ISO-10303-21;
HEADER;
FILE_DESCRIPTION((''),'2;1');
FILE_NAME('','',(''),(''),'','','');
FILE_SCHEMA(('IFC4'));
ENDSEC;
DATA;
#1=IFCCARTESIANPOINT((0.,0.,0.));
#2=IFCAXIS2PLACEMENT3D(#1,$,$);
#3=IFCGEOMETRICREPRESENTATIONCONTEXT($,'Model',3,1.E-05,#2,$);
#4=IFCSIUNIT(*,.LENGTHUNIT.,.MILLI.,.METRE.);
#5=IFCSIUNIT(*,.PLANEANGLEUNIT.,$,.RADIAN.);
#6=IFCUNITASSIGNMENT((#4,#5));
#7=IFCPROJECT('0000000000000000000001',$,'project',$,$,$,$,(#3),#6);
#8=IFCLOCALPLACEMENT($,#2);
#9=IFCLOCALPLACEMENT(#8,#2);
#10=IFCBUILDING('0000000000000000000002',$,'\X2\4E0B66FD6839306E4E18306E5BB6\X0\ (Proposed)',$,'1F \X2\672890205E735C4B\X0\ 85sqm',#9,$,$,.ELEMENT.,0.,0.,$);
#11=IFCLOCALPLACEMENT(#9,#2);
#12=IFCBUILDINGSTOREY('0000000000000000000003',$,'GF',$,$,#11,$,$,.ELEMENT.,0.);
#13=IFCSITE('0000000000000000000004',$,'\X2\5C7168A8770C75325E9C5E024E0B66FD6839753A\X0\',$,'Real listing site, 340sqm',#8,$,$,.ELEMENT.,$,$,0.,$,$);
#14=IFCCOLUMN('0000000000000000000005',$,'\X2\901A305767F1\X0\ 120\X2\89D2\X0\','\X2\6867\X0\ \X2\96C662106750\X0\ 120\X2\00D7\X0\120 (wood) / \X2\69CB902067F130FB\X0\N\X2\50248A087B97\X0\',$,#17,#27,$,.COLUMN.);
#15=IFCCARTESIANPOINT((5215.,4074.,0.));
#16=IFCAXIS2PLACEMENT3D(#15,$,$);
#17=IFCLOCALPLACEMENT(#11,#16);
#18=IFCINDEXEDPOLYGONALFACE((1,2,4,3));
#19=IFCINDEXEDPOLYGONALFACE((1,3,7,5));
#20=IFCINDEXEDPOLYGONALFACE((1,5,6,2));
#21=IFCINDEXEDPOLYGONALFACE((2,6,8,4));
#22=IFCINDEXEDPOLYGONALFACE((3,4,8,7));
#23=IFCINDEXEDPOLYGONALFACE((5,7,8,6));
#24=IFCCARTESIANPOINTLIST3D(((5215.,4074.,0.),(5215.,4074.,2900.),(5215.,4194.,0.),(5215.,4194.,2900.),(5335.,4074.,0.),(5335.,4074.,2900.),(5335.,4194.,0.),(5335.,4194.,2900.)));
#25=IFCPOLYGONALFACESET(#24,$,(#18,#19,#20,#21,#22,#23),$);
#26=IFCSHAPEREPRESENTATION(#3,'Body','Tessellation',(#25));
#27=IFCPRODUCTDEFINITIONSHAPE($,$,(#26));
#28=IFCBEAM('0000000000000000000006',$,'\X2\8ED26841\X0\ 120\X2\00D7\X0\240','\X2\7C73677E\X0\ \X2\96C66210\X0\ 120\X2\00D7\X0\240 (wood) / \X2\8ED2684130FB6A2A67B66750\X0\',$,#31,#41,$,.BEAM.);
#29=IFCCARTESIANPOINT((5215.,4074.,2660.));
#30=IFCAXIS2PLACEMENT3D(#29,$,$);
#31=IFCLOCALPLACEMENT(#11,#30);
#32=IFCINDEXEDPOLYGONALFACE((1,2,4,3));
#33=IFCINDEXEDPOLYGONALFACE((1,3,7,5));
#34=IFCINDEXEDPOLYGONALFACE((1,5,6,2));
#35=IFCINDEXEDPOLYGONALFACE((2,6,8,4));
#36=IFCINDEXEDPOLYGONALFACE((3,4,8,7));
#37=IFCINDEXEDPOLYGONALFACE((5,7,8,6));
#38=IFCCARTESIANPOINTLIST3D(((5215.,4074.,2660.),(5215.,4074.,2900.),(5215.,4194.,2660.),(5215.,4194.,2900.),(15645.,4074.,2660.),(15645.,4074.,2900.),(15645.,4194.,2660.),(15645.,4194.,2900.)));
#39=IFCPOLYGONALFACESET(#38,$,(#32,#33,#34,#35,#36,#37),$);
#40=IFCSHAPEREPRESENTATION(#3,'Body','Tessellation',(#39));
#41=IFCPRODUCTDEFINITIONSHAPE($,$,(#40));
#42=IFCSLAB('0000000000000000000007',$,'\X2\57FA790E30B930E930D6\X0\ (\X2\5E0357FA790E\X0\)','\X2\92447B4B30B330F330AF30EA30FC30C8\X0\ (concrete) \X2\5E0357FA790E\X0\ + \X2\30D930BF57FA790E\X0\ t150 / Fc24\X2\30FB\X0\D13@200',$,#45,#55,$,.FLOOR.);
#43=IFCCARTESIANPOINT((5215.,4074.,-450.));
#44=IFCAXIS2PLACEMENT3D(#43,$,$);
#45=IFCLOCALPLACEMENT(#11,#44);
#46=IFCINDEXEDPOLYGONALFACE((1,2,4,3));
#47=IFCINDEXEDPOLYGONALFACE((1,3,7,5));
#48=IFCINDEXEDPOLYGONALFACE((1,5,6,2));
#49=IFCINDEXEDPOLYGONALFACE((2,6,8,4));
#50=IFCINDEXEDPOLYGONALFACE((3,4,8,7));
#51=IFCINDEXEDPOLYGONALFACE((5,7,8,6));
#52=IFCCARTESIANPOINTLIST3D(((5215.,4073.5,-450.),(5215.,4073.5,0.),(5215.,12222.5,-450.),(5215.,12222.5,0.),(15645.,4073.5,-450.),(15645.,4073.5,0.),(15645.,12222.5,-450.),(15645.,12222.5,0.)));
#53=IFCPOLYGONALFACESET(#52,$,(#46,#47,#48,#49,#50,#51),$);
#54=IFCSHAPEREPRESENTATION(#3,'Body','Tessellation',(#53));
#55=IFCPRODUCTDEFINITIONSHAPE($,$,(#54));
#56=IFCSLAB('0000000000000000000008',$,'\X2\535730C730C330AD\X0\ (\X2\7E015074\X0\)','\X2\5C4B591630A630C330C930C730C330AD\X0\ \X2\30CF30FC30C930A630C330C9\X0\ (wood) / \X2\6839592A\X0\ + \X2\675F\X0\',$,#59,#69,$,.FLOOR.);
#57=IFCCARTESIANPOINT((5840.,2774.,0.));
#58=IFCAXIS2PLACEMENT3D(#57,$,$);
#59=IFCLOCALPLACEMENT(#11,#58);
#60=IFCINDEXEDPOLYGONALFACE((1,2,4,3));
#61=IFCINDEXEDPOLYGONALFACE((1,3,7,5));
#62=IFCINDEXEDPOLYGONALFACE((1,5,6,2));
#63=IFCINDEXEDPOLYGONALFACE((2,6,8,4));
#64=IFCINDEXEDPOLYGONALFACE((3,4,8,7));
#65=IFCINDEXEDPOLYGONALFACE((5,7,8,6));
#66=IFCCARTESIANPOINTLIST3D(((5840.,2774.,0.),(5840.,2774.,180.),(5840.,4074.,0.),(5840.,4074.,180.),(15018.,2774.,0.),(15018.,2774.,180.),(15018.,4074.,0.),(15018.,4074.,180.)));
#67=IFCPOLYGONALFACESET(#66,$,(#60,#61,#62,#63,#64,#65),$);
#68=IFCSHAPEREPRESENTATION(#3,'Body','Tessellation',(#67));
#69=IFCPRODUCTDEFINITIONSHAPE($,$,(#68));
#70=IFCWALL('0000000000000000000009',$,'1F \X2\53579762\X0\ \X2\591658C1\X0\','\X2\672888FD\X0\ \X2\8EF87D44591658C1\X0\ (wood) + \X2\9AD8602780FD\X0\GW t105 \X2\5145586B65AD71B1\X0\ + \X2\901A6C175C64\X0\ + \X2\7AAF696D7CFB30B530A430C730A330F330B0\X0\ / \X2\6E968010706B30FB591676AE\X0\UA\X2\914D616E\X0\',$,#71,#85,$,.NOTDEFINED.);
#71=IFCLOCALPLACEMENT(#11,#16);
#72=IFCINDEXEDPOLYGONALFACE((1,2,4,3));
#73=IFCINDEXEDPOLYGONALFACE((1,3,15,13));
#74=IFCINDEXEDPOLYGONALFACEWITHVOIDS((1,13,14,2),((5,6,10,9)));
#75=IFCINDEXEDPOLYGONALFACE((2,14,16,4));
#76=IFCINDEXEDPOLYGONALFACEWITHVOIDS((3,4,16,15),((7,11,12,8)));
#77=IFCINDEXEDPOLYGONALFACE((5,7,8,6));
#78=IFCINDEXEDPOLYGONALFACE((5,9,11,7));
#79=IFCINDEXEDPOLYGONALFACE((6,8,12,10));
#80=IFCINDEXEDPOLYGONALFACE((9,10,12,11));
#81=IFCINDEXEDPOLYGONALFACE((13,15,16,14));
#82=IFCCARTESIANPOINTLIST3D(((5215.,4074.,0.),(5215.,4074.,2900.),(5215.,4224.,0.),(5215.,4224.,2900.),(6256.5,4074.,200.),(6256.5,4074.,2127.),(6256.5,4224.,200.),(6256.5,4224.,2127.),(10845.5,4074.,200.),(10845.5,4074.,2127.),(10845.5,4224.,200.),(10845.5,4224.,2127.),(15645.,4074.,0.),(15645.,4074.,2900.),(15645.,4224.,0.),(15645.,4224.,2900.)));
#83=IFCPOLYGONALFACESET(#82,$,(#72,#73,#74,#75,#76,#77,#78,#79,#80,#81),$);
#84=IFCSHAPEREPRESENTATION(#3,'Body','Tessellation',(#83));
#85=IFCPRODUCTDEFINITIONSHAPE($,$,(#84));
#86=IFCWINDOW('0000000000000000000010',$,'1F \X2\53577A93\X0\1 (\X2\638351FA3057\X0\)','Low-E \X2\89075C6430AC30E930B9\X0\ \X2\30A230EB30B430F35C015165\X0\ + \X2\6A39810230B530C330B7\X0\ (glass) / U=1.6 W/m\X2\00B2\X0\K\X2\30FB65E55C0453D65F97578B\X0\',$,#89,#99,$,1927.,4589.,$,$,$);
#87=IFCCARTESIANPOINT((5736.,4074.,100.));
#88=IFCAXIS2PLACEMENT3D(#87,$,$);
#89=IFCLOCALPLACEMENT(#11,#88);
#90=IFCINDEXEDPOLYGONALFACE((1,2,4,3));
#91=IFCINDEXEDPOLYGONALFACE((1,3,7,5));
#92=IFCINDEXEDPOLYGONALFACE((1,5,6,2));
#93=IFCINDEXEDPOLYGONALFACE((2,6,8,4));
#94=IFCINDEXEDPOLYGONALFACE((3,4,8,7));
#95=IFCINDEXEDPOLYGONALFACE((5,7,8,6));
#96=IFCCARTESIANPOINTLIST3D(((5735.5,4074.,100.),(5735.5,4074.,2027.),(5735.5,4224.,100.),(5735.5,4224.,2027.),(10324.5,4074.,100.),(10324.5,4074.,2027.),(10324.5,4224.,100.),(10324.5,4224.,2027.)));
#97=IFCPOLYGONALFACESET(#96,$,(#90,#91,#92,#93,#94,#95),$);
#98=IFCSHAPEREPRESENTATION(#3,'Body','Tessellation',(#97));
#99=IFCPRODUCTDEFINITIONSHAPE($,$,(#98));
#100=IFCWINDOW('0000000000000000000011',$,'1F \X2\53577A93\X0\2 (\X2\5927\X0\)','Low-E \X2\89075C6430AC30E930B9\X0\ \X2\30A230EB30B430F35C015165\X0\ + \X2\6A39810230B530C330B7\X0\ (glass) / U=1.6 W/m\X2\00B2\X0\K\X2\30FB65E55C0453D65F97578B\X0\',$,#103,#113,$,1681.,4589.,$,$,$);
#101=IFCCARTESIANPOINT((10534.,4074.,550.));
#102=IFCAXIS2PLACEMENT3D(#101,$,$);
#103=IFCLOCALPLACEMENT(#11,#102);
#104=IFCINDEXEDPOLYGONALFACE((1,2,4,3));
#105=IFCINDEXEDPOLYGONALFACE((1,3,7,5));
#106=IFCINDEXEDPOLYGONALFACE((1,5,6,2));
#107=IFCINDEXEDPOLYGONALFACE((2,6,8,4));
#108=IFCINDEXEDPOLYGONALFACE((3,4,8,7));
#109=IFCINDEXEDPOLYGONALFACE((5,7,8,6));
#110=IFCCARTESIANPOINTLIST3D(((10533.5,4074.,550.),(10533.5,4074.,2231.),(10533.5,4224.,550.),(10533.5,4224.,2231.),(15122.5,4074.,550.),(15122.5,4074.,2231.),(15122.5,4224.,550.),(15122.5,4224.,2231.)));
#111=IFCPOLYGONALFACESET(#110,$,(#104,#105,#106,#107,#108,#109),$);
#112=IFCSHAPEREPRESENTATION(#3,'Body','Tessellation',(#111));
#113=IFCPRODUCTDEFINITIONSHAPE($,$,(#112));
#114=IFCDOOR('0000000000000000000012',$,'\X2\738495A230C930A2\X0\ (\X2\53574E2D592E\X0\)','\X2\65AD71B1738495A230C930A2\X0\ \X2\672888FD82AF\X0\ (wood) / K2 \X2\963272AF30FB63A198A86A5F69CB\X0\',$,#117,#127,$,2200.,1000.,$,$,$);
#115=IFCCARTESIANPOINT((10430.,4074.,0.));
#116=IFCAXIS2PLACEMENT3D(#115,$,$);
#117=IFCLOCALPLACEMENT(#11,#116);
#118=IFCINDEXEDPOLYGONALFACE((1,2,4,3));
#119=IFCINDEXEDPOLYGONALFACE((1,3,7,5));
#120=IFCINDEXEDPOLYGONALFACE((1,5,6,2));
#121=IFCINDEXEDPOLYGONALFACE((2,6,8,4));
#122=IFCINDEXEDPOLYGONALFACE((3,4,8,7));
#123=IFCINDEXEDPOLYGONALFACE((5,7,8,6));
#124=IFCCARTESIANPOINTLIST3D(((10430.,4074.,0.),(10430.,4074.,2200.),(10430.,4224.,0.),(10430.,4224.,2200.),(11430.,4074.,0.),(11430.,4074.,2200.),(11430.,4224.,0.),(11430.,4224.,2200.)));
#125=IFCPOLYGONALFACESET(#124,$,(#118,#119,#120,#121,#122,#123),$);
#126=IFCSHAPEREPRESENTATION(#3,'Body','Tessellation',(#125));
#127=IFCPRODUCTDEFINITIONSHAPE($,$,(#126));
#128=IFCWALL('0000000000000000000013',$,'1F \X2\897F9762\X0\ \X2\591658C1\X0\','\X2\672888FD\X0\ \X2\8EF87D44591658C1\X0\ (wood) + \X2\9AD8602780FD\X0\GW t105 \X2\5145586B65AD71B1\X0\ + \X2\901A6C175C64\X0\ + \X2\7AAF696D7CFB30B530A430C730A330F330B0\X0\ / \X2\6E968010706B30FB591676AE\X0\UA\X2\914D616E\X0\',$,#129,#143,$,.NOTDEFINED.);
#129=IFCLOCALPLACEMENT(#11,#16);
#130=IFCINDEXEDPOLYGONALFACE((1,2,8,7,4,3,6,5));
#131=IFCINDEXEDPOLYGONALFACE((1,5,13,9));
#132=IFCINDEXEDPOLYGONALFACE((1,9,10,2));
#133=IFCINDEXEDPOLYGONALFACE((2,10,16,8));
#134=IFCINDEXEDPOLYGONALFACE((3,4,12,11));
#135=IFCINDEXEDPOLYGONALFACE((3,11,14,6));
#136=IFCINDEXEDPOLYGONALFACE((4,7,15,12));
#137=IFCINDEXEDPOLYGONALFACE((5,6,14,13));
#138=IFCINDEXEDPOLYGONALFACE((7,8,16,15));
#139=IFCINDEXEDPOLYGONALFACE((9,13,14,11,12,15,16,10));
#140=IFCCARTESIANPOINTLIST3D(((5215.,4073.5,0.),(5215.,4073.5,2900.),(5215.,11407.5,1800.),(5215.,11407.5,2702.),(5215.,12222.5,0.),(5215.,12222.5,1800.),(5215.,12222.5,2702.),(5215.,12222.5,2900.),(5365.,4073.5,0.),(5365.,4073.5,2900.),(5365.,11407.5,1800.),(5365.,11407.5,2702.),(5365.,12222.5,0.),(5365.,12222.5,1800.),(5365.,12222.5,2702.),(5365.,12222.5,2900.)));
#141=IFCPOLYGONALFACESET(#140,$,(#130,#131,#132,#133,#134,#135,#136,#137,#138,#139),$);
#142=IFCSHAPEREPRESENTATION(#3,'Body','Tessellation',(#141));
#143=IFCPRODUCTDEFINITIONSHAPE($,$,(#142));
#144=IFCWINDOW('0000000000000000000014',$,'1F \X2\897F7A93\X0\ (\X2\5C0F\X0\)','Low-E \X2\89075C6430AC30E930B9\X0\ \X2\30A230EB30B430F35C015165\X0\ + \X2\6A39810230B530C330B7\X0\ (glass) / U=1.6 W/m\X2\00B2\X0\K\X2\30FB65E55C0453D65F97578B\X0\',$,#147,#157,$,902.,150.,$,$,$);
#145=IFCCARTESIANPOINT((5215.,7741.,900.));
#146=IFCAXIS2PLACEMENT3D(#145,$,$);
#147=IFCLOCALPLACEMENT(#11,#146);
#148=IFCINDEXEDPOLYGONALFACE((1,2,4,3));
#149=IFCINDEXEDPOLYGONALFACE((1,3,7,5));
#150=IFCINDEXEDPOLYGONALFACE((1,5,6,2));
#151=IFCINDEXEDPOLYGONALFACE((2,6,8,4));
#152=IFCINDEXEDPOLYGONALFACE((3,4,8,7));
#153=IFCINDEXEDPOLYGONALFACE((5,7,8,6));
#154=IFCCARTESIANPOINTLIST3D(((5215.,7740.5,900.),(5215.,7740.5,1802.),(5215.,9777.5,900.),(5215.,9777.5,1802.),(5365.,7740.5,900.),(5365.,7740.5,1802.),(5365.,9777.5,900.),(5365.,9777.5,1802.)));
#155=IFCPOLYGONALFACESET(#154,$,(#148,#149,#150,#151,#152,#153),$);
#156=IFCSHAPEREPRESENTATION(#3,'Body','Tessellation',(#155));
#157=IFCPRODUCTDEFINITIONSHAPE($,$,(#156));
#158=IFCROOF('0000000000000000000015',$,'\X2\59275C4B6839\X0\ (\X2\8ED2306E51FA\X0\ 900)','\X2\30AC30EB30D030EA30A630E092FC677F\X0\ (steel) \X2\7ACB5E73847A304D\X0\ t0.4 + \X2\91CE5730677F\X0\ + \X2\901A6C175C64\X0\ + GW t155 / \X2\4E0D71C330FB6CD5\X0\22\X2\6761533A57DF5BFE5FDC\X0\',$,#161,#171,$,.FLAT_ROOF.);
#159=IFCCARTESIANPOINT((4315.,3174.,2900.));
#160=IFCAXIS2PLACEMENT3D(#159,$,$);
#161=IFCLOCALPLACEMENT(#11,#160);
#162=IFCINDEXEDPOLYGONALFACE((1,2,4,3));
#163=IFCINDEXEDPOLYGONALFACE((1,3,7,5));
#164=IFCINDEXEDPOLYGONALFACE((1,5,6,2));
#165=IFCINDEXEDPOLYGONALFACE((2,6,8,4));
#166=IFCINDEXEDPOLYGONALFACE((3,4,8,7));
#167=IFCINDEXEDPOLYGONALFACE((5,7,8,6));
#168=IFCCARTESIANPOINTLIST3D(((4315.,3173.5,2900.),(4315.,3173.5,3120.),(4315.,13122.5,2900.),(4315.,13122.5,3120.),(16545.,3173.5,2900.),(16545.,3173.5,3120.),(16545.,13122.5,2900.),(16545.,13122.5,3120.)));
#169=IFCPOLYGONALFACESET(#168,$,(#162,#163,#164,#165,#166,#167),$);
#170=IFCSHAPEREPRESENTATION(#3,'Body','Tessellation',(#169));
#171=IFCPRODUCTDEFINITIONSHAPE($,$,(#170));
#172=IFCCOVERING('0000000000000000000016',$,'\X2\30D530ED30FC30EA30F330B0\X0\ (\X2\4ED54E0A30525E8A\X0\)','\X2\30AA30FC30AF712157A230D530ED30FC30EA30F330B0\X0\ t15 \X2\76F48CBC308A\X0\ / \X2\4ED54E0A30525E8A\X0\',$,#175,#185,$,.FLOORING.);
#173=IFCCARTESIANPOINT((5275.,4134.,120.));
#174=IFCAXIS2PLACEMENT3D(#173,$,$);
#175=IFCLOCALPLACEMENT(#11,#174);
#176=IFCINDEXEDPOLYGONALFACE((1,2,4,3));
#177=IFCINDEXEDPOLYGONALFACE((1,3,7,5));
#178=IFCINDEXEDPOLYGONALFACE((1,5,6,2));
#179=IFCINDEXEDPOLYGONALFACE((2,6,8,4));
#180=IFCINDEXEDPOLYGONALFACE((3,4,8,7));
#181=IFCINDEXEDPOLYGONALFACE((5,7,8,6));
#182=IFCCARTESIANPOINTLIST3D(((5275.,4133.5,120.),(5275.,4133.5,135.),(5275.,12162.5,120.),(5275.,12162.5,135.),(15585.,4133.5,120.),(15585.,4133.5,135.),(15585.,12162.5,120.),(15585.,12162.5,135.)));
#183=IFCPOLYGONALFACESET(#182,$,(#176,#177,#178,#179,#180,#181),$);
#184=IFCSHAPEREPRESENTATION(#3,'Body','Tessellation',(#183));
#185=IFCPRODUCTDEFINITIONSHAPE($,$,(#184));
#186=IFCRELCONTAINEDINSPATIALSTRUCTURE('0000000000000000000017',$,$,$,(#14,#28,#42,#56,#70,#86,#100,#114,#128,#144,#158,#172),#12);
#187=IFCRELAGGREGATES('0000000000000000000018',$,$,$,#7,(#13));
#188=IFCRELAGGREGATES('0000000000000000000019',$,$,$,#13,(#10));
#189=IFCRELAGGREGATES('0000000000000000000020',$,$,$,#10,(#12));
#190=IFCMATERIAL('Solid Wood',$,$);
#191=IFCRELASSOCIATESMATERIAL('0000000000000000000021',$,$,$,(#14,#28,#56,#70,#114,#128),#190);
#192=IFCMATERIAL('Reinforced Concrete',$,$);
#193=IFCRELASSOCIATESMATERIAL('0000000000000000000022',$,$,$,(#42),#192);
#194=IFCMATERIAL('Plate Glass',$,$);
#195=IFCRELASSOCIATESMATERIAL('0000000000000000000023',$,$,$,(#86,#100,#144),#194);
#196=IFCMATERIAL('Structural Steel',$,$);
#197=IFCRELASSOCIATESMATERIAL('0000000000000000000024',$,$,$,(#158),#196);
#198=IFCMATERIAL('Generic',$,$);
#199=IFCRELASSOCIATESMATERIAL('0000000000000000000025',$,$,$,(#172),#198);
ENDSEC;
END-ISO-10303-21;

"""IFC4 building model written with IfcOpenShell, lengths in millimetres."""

from ifc_helpers import new_model, si_unit, frame, frame_2d, origin, place, context, project, spatial, rectangle, extrude, material, element, fill, save


model = new_model("IFC4")

# Units and contexts
model_context = context("Model", 3, precision=1e-05, world=origin())
ifc_project = project(units=[si_unit("LENGTHUNIT", "METRE", prefix="MILLI"), si_unit("PLANEANGLEUNIT", "RADIAN")], contexts=[model_context])

# Site, building, storey
site_placement = place(None, origin())
site = spatial("IfcSite", under=ifc_project, at=site_placement, Name="山梨県甲府市下曽根町", ObjectType="Real listing site, 340sqm", CompositionType="ELEMENT", RefElevation=0.0)
building_placement = place(site_placement, origin())
building = spatial("IfcBuilding", under=site, at=building_placement, Name="下曽根の丘の家 (Proposed)", ObjectType="1F 木造平屋 85sqm", CompositionType="ELEMENT", ElevationOfRefHeight=0.0, ElevationOfTerrain=0.0)
storey_placement = place(building_placement, origin())
storey = spatial("IfcBuildingStorey", under=building, at=storey_placement, Name="GF", CompositionType="ELEMENT", Elevation=0.0)

# Column
ifc_material_1 = material(Name="Solid Wood")
column_1_placement = place(storey_placement, frame((5215.0, 4074.0, 0.0)))
element("IfcColumn", 1, at=column_1_placement, inside=storey, material=ifc_material_1, Name="通し柱 120角", Description="桧 集成材 120×120 (wood) / 構造柱・N値計算", PredefinedType="COLUMN", context=model_context, shape_type="SweptSolid", body=[
    extrude(rectangle(XDim=120.0, YDim=120.0, at=frame_2d((60.0, 60.0))), frame((5215.0, 4074.0, 0.0)), (0.0, 0.0, 1.0), 2900.0),
])

# Beam
beam_1_placement = place(storey_placement, frame((5215.0, 4074.0, 2660.0)))
element("IfcBeam", 2, at=beam_1_placement, inside=storey, material=ifc_material_1, Name="軒桁 120×240", Description="米松 集成 120×240 (wood) / 軒桁・横架材", PredefinedType="BEAM", context=model_context, shape_type="SweptSolid", body=[
    extrude(rectangle(XDim=10430.0, YDim=120.0, at=frame_2d((5215.0, 60.0))), frame((5215.0, 4074.0, 2660.0)), (0.0, 0.0, 1.0), 240.0),
])

# Slabs
ifc_material_2 = material(Name="Reinforced Concrete")
slab_1_placement = place(storey_placement, frame((5215.0, 4074.0, -450.0)))
element("IfcSlab", 3, at=slab_1_placement, inside=storey, material=ifc_material_2, Name="基礎スラブ (布基礎)", Description="鉄筋コンクリート (concrete) 布基礎 + ベタ基礎 t150 / Fc24・D13@200", PredefinedType="FLOOR", context=model_context, shape_type="SweptSolid", body=[
    extrude(rectangle(XDim=10430.0, YDim=8149.0, at=frame_2d((5215.0, 4074.0))), frame((5215.0, 4074.0, -450.0)), (0.0, 0.0, 1.0), 450.0),
])
slab_2_placement = place(storey_placement, frame((5840.0, 2774.0, 0.0)))
element("IfcSlab", 4, at=slab_2_placement, inside=storey, material=ifc_material_1, Name="南デッキ (縁側)", Description="屋外ウッドデッキ ハードウッド (wood) / 根太 + 束", PredefinedType="FLOOR", context=model_context, shape_type="SweptSolid", body=[
    extrude(rectangle(XDim=9178.0, YDim=1300.0, at=frame_2d((4589.0, 650.0))), frame((5840.0, 2774.0, 0.0)), (0.0, 0.0, 1.0), 180.0),
])

# Wall, openings, windows, door
wall_1_placement = place(storey_placement, frame((5215.0, 4074.0, 0.0)))
wall_1 = element("IfcWall", 5, at=wall_1_placement, inside=storey, material=ifc_material_1, Name="1F 南面 外壁", Description="木製 軸組外壁 (wood) + 高性能GW t105 充填断熱 + 通気層 + 窯業系サイディング / 準耐火・外皮UA配慮", PredefinedType="NOTDEFINED", context=model_context, shape_type="SweptSolid", body=[
    extrude(rectangle(XDim=10430.0, YDim=150.0, at=frame_2d((5215.0, 75.0))), frame((5215.0, 4074.0, 0.0)), (0.0, 0.0, 1.0), 2900.0),
])
opening_1_placement = place(storey_placement, frame((5736.0, 4074.0, 100.0)))
opening_1 = element("IfcOpeningElement", 6, at=opening_1_placement, cuts=wall_1, PredefinedType="NOTDEFINED", context=model_context, shape_type="SweptSolid", body=[
    extrude(rectangle(XDim=4589.0, YDim=150.0, at=frame_2d((2294.0, 75.0))), frame((5736.0, 4074.0, 100.0)), (0.0, 0.0, 1.0), 1927.0),
])
opening_2_placement = place(storey_placement, frame((10534.0, 4074.0, 550.0)))
opening_2 = element("IfcOpeningElement", 7, at=opening_2_placement, cuts=wall_1, PredefinedType="NOTDEFINED", context=model_context, shape_type="SweptSolid", body=[
    extrude(rectangle(XDim=4589.0, YDim=150.0, at=frame_2d((2294.0, 75.0))), frame((10534.0, 4074.0, 550.0)), (0.0, 0.0, 1.0), 1681.0),
])
opening_3_placement = place(storey_placement, frame((10430.0, 4074.0, 0.0)))
opening_3 = element("IfcOpeningElement", 8, at=opening_3_placement, cuts=wall_1, PredefinedType="NOTDEFINED", context=model_context, shape_type="SweptSolid", body=[
    extrude(rectangle(XDim=1000.0, YDim=150.0, at=frame_2d((500.0, 75.0))), frame((10430.0, 4074.0, 0.0)), (0.0, 0.0, 1.0), 2200.0),
])
ifc_material_3 = material(Name="Plate Glass")
window_1_placement = place(storey_placement, frame((5736.0, 4074.0, 100.0)))
window_1 = element("IfcWindow", 9, at=window_1_placement, inside=storey, material=ifc_material_3, Name="1F 南窓1 (掃出し)", Description="Low-E 複層ガラス アルゴン封入 + 樹脂サッシ (glass) / U=1.6 W/m²K・日射取得型", OverallHeight=1927.0, OverallWidth=4589.0, context=model_context, shape_type="SweptSolid", body=[
    extrude(rectangle(XDim=4589.0, YDim=150.0, at=frame_2d((2294.0, 75.0))), frame((5736.0, 4074.0, 100.0)), (0.0, 0.0, 1.0), 1927.0),
])
fill(opening_1, window_1)
window_2_placement = place(storey_placement, frame((10534.0, 4074.0, 550.0)))
window_2 = element("IfcWindow", 10, at=window_2_placement, inside=storey, material=ifc_material_3, Name="1F 南窓2 (大)", Description="Low-E 複層ガラス アルゴン封入 + 樹脂サッシ (glass) / U=1.6 W/m²K・日射取得型", OverallHeight=1681.0, OverallWidth=4589.0, context=model_context, shape_type="SweptSolid", body=[
    extrude(rectangle(XDim=4589.0, YDim=150.0, at=frame_2d((2294.0, 75.0))), frame((10534.0, 4074.0, 550.0)), (0.0, 0.0, 1.0), 1681.0),
])
fill(opening_2, window_2)
door_placement = place(storey_placement, frame((10430.0, 4074.0, 0.0)))
door = element("IfcDoor", 11, at=door_placement, inside=storey, material=ifc_material_1, Name="玄関ドア (南中央)", Description="断熱玄関ドア 木製芯 (wood) / K2 防犯・採風機構", OverallHeight=2200.0, OverallWidth=1000.0, context=model_context, shape_type="SweptSolid", body=[
    extrude(rectangle(XDim=1000.0, YDim=150.0, at=frame_2d((500.0, 75.0))), frame((10430.0, 4074.0, 0.0)), (0.0, 0.0, 1.0), 2200.0),
])
fill(opening_3, door)

# Wall, opening, window
wall_2_placement = place(storey_placement, frame((5215.0, 4074.0, 0.0)))
wall_2 = element("IfcWall", 12, at=wall_2_placement, inside=storey, material=ifc_material_1, Name="1F 西面 外壁", Description="木製 軸組外壁 (wood) + 高性能GW t105 充填断熱 + 通気層 + 窯業系サイディング / 準耐火・外皮UA配慮", PredefinedType="NOTDEFINED", context=model_context, shape_type="SweptSolid", body=[
    extrude(rectangle(XDim=150.0, YDim=8149.0, at=frame_2d((75.0, 4074.0))), frame((5215.0, 4074.0, 0.0)), (0.0, 0.0, 1.0), 2900.0),
])
opening_4_placement = place(storey_placement, frame((5215.0, 7741.0, 900.0)))
opening_4 = element("IfcOpeningElement", 13, at=opening_4_placement, cuts=wall_2, PredefinedType="NOTDEFINED", context=model_context, shape_type="SweptSolid", body=[
    extrude(rectangle(XDim=150.0, YDim=2037.0, at=frame_2d((75.0, 1018.0))), frame((5215.0, 7741.0, 900.0)), (0.0, 0.0, 1.0), 902.0),
])
window_3_placement = place(storey_placement, frame((5215.0, 7741.0, 900.0)))
window_3 = element("IfcWindow", 14, at=window_3_placement, inside=storey, material=ifc_material_3, Name="1F 西窓 (小)", Description="Low-E 複層ガラス アルゴン封入 + 樹脂サッシ (glass) / U=1.6 W/m²K・日射取得型", OverallHeight=902.0, OverallWidth=150.0, context=model_context, shape_type="SweptSolid", body=[
    extrude(rectangle(XDim=150.0, YDim=2037.0, at=frame_2d((75.0, 1018.0))), frame((5215.0, 7741.0, 900.0)), (0.0, 0.0, 1.0), 902.0),
])
fill(opening_4, window_3)

# Roof
ifc_material_4 = material(Name="Structural Steel")
roof_placement = place(storey_placement, frame((4315.0, 3174.0, 2900.0)))
element("IfcRoof", 15, at=roof_placement, inside=storey, material=ifc_material_4, Name="大屋根 (軒の出 900)", Description="ガルバリウム鋼板 (steel) 立平葺き t0.4 + 野地板 + 通気層 + GW t155 / 不燃・法22条区域対応", PredefinedType="FLAT_ROOF", context=model_context, shape_type="SweptSolid", body=[
    extrude(rectangle(XDim=12230.0, YDim=9949.0, at=frame_2d((6115.0, 4974.0))), frame((4315.0, 3174.0, 2900.0)), (0.0, 0.0, 1.0), 220.0),
])

# Covering
ifc_material_5 = material(Name="Generic")
covering_1_placement = place(storey_placement, frame((5275.0, 4134.0, 120.0)))
element("IfcCovering", 16, at=covering_1_placement, inside=storey, material=ifc_material_5, Name="フローリング (仕上げ床)", Description="オーク無垢フローリング t15 直貼り / 仕上げ床", PredefinedType="FLOORING", context=model_context, shape_type="SweptSolid", body=[
    extrude(rectangle(XDim=10310.0, YDim=8029.0, at=frame_2d((5155.0, 4014.0))), frame((5275.0, 4134.0, 120.0)), (0.0, 0.0, 1.0), 15.0),
])

save(model, "model.ifc")
